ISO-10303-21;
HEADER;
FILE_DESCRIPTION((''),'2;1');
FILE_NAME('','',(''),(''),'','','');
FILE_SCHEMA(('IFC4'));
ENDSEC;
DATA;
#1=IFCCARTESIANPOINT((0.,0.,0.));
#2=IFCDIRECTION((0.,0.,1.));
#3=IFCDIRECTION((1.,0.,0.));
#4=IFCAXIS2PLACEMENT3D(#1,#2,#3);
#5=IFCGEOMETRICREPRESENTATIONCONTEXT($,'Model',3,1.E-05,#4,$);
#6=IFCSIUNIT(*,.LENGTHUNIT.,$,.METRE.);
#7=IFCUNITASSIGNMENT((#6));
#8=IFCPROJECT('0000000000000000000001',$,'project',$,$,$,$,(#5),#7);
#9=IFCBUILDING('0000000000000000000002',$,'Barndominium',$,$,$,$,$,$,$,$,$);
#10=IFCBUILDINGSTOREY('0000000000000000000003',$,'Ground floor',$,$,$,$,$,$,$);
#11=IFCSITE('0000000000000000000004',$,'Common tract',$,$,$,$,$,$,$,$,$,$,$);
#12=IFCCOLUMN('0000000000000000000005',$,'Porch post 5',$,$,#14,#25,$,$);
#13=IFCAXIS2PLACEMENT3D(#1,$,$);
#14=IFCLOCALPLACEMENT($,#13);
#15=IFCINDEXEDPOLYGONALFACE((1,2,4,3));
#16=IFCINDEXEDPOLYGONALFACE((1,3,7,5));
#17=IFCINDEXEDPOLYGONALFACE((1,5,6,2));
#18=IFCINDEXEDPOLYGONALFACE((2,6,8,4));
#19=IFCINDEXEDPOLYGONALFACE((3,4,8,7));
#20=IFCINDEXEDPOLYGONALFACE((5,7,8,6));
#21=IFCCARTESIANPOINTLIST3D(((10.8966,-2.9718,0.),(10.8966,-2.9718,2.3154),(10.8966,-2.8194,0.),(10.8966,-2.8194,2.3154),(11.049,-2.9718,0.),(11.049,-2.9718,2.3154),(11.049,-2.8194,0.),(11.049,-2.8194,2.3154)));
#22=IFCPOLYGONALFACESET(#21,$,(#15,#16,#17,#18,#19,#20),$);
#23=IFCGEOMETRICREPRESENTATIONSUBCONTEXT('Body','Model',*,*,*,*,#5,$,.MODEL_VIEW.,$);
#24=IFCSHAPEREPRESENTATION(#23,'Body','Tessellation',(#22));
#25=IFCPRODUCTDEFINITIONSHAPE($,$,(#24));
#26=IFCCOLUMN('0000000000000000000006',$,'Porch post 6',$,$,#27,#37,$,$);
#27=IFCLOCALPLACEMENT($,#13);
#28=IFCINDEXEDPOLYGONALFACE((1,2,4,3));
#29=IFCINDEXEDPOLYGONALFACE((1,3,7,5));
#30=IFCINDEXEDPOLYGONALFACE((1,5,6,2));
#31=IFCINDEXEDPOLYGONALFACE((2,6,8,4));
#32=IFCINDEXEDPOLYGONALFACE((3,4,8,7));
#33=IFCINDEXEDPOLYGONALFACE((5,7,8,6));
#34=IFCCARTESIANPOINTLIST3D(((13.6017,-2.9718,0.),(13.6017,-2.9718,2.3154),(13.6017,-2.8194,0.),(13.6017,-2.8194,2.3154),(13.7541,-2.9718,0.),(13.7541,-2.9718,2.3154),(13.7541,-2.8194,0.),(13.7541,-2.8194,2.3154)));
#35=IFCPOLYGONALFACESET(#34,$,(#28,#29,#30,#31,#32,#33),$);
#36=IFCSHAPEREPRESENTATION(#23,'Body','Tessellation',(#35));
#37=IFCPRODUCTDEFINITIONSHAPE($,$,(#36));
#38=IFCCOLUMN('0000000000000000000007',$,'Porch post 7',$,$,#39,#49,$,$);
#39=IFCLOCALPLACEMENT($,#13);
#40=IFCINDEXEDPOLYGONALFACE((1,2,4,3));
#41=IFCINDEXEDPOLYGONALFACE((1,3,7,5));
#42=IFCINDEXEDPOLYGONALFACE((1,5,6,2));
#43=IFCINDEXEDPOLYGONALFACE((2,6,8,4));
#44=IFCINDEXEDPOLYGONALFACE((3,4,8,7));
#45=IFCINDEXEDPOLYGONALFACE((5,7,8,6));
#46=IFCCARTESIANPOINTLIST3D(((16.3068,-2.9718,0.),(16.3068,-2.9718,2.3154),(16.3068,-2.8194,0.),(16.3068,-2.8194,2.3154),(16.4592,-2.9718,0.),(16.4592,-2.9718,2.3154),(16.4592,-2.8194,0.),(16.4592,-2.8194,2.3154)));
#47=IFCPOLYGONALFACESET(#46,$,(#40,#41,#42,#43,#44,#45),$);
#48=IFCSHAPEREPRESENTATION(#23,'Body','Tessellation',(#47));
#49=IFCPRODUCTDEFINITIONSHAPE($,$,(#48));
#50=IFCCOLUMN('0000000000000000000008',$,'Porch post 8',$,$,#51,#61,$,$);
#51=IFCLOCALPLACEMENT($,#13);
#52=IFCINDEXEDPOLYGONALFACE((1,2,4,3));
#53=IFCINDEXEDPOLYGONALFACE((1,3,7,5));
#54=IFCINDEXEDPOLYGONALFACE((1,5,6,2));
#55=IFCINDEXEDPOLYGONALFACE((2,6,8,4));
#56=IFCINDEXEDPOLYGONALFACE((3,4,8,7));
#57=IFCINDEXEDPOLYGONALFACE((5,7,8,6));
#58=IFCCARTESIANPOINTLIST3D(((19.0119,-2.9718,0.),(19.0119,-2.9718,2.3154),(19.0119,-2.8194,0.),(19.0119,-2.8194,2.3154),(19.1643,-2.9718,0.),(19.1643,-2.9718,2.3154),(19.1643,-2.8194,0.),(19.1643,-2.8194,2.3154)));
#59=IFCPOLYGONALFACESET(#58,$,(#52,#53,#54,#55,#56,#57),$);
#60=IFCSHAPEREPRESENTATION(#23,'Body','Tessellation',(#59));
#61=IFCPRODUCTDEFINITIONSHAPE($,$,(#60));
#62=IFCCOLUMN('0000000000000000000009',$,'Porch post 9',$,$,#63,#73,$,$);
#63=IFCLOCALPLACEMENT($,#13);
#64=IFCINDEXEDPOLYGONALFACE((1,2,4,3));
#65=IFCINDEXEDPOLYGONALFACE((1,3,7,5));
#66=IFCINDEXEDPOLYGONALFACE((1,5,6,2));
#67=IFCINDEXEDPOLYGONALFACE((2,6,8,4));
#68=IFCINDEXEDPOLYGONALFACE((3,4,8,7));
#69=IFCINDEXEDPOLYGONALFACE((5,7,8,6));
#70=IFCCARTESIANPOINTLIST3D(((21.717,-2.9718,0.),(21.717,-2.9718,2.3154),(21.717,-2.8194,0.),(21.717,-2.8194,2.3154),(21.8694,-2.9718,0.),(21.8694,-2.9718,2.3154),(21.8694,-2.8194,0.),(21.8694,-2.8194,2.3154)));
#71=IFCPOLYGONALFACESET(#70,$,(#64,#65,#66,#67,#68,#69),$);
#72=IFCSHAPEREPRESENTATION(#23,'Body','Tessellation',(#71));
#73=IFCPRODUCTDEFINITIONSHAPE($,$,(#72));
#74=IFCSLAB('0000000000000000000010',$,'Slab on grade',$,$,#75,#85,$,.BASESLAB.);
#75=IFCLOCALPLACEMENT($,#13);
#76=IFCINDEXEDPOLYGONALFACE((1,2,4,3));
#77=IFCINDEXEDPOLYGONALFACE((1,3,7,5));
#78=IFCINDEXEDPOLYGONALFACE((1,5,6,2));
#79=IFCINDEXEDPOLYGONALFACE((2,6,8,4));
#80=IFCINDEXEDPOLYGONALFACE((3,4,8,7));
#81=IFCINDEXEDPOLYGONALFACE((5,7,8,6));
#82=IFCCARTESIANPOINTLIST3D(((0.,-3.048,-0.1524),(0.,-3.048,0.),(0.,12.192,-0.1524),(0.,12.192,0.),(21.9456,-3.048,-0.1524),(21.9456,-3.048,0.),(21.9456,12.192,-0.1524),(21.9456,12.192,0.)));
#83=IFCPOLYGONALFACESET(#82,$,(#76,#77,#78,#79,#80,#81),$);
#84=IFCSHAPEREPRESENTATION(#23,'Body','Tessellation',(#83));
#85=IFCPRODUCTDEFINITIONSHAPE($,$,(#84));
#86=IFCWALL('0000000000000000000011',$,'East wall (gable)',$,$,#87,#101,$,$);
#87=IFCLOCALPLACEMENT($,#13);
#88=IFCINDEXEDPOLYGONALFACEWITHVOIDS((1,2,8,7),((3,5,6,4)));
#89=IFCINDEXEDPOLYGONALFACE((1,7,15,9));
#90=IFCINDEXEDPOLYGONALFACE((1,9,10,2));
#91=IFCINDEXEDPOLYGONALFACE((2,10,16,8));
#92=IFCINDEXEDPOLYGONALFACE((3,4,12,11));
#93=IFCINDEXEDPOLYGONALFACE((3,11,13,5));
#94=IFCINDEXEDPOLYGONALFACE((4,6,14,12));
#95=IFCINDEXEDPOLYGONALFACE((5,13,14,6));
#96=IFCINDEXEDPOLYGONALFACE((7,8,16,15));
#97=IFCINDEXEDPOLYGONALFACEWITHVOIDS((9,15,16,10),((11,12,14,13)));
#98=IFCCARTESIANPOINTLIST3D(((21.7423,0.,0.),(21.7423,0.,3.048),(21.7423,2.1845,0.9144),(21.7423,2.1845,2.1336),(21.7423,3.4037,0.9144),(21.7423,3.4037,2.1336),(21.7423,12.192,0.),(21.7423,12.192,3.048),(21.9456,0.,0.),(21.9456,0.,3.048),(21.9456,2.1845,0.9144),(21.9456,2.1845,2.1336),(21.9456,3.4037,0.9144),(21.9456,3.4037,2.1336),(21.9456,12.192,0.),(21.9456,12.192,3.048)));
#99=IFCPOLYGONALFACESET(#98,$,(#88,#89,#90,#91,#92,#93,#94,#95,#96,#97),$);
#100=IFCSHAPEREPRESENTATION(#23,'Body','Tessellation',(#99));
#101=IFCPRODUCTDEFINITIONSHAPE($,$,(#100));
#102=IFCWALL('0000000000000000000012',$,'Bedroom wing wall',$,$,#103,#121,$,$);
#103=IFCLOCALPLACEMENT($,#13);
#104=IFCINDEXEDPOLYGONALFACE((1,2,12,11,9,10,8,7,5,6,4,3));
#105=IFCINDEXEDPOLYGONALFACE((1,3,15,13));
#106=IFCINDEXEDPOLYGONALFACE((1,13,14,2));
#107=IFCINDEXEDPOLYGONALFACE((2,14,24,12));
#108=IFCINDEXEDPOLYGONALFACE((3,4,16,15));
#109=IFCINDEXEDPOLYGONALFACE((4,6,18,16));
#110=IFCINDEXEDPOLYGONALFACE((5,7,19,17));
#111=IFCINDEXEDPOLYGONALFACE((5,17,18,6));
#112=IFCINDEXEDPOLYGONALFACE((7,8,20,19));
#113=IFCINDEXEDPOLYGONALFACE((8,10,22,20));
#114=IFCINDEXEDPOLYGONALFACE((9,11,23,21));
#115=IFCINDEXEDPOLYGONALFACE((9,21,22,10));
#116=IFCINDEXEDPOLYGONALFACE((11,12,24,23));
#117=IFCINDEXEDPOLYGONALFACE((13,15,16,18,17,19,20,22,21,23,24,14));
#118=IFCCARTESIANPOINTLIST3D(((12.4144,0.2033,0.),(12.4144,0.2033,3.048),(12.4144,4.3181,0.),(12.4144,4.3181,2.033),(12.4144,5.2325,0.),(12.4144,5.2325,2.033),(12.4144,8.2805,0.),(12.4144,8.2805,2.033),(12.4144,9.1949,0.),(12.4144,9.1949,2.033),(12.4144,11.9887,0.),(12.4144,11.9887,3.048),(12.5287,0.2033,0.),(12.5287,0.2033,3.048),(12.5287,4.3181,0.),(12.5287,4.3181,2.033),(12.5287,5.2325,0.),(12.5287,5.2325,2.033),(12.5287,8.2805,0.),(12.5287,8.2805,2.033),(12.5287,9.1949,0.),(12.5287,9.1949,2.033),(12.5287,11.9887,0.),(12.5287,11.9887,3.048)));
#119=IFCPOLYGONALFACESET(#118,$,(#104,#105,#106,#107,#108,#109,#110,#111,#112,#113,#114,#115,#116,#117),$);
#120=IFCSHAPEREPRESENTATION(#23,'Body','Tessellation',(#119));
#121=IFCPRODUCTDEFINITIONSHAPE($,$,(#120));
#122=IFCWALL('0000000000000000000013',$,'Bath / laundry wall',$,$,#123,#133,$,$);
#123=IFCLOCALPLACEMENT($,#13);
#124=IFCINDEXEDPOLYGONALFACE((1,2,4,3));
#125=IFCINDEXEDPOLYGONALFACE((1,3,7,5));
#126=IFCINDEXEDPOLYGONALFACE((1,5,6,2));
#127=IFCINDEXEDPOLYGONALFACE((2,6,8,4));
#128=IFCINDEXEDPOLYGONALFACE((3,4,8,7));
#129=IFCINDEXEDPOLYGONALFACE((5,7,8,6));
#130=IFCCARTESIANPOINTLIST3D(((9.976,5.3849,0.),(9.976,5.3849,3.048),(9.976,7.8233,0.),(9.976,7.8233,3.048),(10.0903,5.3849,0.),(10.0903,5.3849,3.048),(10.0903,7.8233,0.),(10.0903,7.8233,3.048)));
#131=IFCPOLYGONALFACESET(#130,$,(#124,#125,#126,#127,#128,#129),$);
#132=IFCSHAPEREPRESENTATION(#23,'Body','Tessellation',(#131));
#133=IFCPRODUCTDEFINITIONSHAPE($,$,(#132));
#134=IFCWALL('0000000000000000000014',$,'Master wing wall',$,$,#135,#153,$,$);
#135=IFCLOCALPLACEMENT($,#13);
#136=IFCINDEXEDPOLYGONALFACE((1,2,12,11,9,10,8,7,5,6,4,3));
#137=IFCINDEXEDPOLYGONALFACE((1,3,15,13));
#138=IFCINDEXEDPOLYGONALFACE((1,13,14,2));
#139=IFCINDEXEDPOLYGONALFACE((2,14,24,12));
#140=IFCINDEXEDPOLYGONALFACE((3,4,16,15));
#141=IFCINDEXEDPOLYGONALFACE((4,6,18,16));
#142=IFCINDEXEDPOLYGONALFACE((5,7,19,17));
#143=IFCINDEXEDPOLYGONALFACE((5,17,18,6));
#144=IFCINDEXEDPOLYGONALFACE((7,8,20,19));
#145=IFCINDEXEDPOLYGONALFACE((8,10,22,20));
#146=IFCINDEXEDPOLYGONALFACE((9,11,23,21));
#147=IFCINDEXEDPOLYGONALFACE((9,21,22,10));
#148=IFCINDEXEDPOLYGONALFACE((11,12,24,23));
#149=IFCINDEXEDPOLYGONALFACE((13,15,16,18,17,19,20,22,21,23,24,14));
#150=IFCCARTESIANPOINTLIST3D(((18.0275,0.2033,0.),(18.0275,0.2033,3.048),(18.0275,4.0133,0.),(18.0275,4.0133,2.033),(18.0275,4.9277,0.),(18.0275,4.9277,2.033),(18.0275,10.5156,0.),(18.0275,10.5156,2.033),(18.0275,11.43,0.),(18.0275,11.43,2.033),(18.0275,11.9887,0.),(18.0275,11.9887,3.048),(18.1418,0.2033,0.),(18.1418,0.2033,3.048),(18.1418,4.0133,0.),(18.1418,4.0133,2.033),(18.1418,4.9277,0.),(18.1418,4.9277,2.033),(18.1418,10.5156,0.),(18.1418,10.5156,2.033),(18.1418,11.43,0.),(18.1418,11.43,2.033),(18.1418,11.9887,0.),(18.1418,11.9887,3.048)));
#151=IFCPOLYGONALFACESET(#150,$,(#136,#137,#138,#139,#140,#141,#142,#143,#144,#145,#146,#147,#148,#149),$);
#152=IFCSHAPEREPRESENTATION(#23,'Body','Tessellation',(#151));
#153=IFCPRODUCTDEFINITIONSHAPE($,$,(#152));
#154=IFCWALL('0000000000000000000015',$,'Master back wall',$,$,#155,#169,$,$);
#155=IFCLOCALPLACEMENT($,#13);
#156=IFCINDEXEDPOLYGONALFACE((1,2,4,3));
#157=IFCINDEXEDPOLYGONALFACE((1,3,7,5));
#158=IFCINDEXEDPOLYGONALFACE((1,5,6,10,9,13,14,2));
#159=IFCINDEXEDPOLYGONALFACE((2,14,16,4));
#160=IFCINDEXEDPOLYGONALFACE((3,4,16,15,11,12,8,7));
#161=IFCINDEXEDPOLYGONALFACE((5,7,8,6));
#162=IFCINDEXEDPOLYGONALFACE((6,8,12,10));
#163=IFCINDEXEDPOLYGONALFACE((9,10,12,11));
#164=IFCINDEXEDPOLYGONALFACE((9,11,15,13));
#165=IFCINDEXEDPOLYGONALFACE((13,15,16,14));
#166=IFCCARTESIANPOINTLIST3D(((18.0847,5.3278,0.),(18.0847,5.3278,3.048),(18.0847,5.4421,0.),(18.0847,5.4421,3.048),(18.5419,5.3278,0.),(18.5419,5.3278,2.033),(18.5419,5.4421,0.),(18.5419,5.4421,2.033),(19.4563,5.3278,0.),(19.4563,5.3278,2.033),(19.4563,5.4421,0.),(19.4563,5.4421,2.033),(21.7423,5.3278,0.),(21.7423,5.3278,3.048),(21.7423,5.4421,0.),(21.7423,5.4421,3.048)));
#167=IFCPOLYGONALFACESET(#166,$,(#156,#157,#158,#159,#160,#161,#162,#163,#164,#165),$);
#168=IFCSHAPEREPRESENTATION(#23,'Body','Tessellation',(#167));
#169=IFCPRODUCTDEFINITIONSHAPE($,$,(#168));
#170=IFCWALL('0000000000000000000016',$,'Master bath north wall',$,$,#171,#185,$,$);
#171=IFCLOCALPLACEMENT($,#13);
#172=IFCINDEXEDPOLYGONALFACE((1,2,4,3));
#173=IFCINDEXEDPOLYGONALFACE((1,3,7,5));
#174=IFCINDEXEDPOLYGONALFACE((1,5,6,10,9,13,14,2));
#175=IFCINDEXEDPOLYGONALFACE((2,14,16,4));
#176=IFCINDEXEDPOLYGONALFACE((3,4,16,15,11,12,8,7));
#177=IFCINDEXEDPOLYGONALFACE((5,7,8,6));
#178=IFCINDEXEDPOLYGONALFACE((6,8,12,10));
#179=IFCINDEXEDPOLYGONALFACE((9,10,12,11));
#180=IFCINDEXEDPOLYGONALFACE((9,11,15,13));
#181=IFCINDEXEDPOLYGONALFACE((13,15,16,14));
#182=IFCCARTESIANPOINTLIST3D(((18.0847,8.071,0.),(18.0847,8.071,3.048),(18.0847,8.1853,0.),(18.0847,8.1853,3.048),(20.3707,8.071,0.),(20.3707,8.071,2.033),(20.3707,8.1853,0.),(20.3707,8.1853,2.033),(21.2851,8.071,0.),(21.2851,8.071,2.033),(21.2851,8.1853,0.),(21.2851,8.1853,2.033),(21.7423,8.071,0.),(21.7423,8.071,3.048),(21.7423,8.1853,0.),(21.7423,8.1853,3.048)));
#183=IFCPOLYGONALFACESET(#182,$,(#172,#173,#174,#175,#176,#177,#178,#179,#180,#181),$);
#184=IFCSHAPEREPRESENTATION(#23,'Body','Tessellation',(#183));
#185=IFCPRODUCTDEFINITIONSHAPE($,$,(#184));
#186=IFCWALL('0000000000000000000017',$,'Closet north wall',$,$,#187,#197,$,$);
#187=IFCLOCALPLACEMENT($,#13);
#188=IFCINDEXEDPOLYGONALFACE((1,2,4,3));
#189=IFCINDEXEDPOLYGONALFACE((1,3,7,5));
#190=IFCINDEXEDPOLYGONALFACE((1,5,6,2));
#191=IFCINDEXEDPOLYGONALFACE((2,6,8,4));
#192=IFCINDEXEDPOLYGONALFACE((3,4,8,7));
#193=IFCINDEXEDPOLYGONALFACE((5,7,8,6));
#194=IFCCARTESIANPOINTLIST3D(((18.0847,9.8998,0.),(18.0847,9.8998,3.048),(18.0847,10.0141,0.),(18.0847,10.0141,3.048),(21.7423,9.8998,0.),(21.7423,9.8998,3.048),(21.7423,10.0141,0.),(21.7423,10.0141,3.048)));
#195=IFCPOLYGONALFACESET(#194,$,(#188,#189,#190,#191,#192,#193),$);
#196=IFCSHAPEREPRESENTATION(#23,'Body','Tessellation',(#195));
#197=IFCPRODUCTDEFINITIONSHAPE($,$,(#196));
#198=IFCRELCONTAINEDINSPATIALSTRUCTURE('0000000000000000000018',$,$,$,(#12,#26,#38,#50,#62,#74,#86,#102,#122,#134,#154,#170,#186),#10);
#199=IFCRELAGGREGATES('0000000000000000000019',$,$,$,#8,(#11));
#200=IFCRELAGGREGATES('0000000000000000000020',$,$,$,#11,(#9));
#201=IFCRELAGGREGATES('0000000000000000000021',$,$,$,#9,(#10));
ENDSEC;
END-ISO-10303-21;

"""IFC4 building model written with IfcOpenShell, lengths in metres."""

from ifc_helpers import new_model, si_unit, frame, origin_with_axes, place, context, subcontext, project, spatial, indexed_curve, rectangle, outline, extrude, element, save


model = new_model("IFC4")

# Units and contexts
model_context = context("Model", 3, precision=1e-05, world=origin_with_axes())
body_context = subcontext(model_context, "Body", "Model", "MODEL_VIEW")
ifc_project = project(units=[si_unit("LENGTHUNIT", "METRE")], contexts=[model_context])

# Site, building, storey
site = spatial("IfcSite", under=ifc_project, Name="Common tract")
building = spatial("IfcBuilding", under=site, Name="Barndominium")
storey = spatial("IfcBuildingStorey", under=building, Name="Ground floor")

# Columns
for number, where, z_axis, x_axis, name in (
    (1, (10.9728, -2.8956, 0.0), (0.0, 0.0, 1.0), (1.0, 0.0, 0.0), "Porch post 5"),
    (2, (13.6779, -2.8956, 0.0), (0.0, 0.0, 1.0), (1.0, 0.0, 0.0), "Porch post 6"),
    (3, (16.383, -2.8956, 0.0), (0.0, 0.0, 1.0), (1.0, 0.0, 0.0), "Porch post 7"),
    (4, (19.0881, -2.8956, 0.0), (0.0, 0.0, 1.0), (1.0, 0.0, 0.0), "Porch post 8"),
    (5, (21.7932, -2.8956, 0.0), (0.0, 0.0, 1.0), (1.0, 0.0, 0.0), "Porch post 9"),
):
    element("IfcColumn", number, at=place(None, frame(where, z_axis=z_axis, x_axis=x_axis)), inside=storey, Name=name, context=body_context, shape_type="SweptSolid", body=[
        extrude(rectangle(XDim=0.1524, YDim=0.1524), origin_with_axes(), (0.0, 0.0, 1.0), 2.3154),
    ])

# Slab
slab_placement = place(None, frame((10.9728, 4.572, -0.1524), z_axis=(0.0, 0.0, 1.0), x_axis=(1.0, 0.0, 0.0)))
element("IfcSlab", 6, at=slab_placement, inside=storey, Name="Slab on grade", PredefinedType="BASESLAB", context=body_context, shape_type="SweptSolid", body=[
    extrude(rectangle(XDim=21.9456, YDim=15.24), origin_with_axes(), (0.0, 0.0, 1.0), 0.1524),
])

# Wall, opening
wall_1_placement = place(None, frame((21.9456, 0.0, 0.0), z_axis=(0.0, 0.0, 1.0), x_axis=(0.0, 1.0, 0.0)))
wall_1 = element("IfcWall", 7, at=wall_1_placement, inside=storey, Name="East wall (gable)", context=body_context, shape_type="SweptSolid", body=[
    extrude(outline(indexed_curve([(0.0, 0.0), (0.0, 0.2033), (12.192, 0.2033), (12.192, 0.0), (0.0, 0.0)], self_intersect=False)), origin_with_axes(), (0.0, 0.0, 1.0), 3.048),
])
opening_1_placement = place(wall_1_placement, frame((2.7941, 0.1017, 0.9144), z_axis=(0.0, 0.0, 1.0), x_axis=(0.0, -1.0, 0.0)))
element("IfcOpeningElement", 8, at=opening_1_placement, cuts=wall_1, context=body_context, shape_type="SweptSolid", body=[
    extrude(rectangle(XDim=0.3033, YDim=1.2192), origin_with_axes(), (0.0, 0.0, 1.0), 1.2192),
])

# Wall, openings
wall_2_placement = place(None, frame((12.5287, 0.2033, 0.0), z_axis=(0.0, 0.0, 1.0), x_axis=(0.0, 1.0, 0.0)))
wall_2 = element("IfcWall", 9, at=wall_2_placement, inside=storey, Name="Bedroom wing wall", context=body_context, shape_type="SweptSolid", body=[
    extrude(outline(indexed_curve([(0.0, 0.0), (0.0, 0.1143), (11.7854, 0.1143), (11.7854, 0.0), (0.0, 0.0)], self_intersect=False)), origin_with_axes(), (0.0, 0.0, 1.0), 3.048),
])
opening_2_placement = place(wall_2_placement, frame((4.572, 0.0572, 0.0), z_axis=(0.0, 0.0, 1.0), x_axis=(0.0, -1.0, 0.0)))
element("IfcOpeningElement", 10, at=opening_2_placement, cuts=wall_2, context=body_context, shape_type="SweptSolid", body=[
    extrude(rectangle(XDim=0.3033, YDim=0.9144), origin_with_axes(), (0.0, 0.0, 1.0), 2.033),
])
opening_3_placement = place(wall_2_placement, frame((8.5344, 0.0572, 0.0), z_axis=(0.0, 0.0, 1.0), x_axis=(0.0, -1.0, 0.0)))
element("IfcOpeningElement", 11, at=opening_3_placement, cuts=wall_2, context=body_context, shape_type="SweptSolid", body=[
    extrude(rectangle(XDim=0.3033, YDim=0.9144), origin_with_axes(), (0.0, 0.0, 1.0), 2.033),
])

# Wall
wall_3_placement = place(None, frame((10.0903, 5.3849, 0.0), z_axis=(0.0, 0.0, 1.0), x_axis=(0.0, 1.0, 0.0)))
element("IfcWall", 12, at=wall_3_placement, inside=storey, Name="Bath / laundry wall", context=body_context, shape_type="SweptSolid", body=[
    extrude(outline(indexed_curve([(0.0, 0.0), (0.0, 0.1143), (2.4384, 0.1143), (2.4384, 0.0), (0.0, 0.0)], self_intersect=False)), origin_with_axes(), (0.0, 0.0, 1.0), 3.048),
])

# Wall, openings
wall_4_placement = place(None, frame((18.1418, 0.2033, 0.0), z_axis=(0.0, 0.0, 1.0), x_axis=(0.0, 1.0, 0.0)))
wall_4 = element("IfcWall", 13, at=wall_4_placement, inside=storey, Name="Master wing wall", context=body_context, shape_type="SweptSolid", body=[
    extrude(outline(indexed_curve([(0.0, 0.0), (0.0, 0.1143), (11.7854, 0.1143), (11.7854, 0.0), (0.0, 0.0)], self_intersect=False)), origin_with_axes(), (0.0, 0.0, 1.0), 3.048),
])
opening_4_placement = place(wall_4_placement, frame((4.2672, 0.0572, 0.0), z_axis=(0.0, 0.0, 1.0), x_axis=(0.0, -1.0, 0.0)))
element("IfcOpeningElement", 14, at=opening_4_placement, cuts=wall_4, context=body_context, shape_type="SweptSolid", body=[
    extrude(rectangle(XDim=0.3033, YDim=0.9144), origin_with_axes(), (0.0, 0.0, 1.0), 2.033),
])
opening_5_placement = place(wall_4_placement, frame((10.7695, 0.0572, 0.0), z_axis=(0.0, 0.0, 1.0), x_axis=(0.0, -1.0, 0.0)))
element("IfcOpeningElement", 15, at=opening_5_placement, cuts=wall_4, context=body_context, shape_type="SweptSolid", body=[
    extrude(rectangle(XDim=0.3033, YDim=0.9144), origin_with_axes(), (0.0, 0.0, 1.0), 2.033),
])

# Walls, openings
wall_5_placement = place(None, frame((18.0847, 5.3278, 0.0), z_axis=(0.0, 0.0, 1.0), x_axis=(1.0, 0.0, 0.0)))
wall_5 = element("IfcWall", 16, at=wall_5_placement, inside=storey, Name="Master back wall", context=body_context, shape_type="SweptSolid", body=[
    extrude(outline(indexed_curve([(0.0, 0.0), (0.0, 0.1143), (3.6576, 0.1143), (3.6576, 0.0), (0.0, 0.0)], self_intersect=False)), origin_with_axes(), (0.0, 0.0, 1.0), 3.048),
])
opening_6_placement = place(wall_5_placement, frame((0.9144, 0.0572, 0.0), z_axis=(0.0, 0.0, 1.0), x_axis=(1.0, 0.0, 0.0)))
element("IfcOpeningElement", 17, at=opening_6_placement, cuts=wall_5, context=body_context, shape_type="SweptSolid", body=[
    extrude(rectangle(XDim=0.9144, YDim=0.3033), origin_with_axes(), (0.0, 0.0, 1.0), 2.033),
])
wall_6_placement = place(None, frame((18.0847, 8.071, 0.0), z_axis=(0.0, 0.0, 1.0), x_axis=(1.0, 0.0, 0.0)))
wall_6 = element("IfcWall", 18, at=wall_6_placement, inside=storey, Name="Master bath north wall", context=body_context, shape_type="SweptSolid", body=[
    extrude(outline(indexed_curve([(0.0, 0.0), (0.0, 0.1143), (3.6576, 0.1143), (3.6576, 0.0), (0.0, 0.0)], self_intersect=False)), origin_with_axes(), (0.0, 0.0, 1.0), 3.048),
])
opening_7_placement = place(wall_6_placement, frame((2.7432, 0.0572, 0.0), z_axis=(0.0, 0.0, 1.0), x_axis=(1.0, 0.0, 0.0)))
element("IfcOpeningElement", 19, at=opening_7_placement, cuts=wall_6, context=body_context, shape_type="SweptSolid", body=[
    extrude(rectangle(XDim=0.9144, YDim=0.3033), origin_with_axes(), (0.0, 0.0, 1.0), 2.033),
])

# Wall
wall_7_placement = place(None, frame((18.0847, 9.8998, 0.0), z_axis=(0.0, 0.0, 1.0), x_axis=(1.0, 0.0, 0.0)))
element("IfcWall", 20, at=wall_7_placement, inside=storey, Name="Closet north wall", context=body_context, shape_type="SweptSolid", body=[
    extrude(outline(indexed_curve([(0.0, 0.0), (0.0, 0.1143), (3.6576, 0.1143), (3.6576, 0.0), (0.0, 0.0)], self_intersect=False)), origin_with_axes(), (0.0, 0.0, 1.0), 3.048),
])

save(model, "model.ifc")
